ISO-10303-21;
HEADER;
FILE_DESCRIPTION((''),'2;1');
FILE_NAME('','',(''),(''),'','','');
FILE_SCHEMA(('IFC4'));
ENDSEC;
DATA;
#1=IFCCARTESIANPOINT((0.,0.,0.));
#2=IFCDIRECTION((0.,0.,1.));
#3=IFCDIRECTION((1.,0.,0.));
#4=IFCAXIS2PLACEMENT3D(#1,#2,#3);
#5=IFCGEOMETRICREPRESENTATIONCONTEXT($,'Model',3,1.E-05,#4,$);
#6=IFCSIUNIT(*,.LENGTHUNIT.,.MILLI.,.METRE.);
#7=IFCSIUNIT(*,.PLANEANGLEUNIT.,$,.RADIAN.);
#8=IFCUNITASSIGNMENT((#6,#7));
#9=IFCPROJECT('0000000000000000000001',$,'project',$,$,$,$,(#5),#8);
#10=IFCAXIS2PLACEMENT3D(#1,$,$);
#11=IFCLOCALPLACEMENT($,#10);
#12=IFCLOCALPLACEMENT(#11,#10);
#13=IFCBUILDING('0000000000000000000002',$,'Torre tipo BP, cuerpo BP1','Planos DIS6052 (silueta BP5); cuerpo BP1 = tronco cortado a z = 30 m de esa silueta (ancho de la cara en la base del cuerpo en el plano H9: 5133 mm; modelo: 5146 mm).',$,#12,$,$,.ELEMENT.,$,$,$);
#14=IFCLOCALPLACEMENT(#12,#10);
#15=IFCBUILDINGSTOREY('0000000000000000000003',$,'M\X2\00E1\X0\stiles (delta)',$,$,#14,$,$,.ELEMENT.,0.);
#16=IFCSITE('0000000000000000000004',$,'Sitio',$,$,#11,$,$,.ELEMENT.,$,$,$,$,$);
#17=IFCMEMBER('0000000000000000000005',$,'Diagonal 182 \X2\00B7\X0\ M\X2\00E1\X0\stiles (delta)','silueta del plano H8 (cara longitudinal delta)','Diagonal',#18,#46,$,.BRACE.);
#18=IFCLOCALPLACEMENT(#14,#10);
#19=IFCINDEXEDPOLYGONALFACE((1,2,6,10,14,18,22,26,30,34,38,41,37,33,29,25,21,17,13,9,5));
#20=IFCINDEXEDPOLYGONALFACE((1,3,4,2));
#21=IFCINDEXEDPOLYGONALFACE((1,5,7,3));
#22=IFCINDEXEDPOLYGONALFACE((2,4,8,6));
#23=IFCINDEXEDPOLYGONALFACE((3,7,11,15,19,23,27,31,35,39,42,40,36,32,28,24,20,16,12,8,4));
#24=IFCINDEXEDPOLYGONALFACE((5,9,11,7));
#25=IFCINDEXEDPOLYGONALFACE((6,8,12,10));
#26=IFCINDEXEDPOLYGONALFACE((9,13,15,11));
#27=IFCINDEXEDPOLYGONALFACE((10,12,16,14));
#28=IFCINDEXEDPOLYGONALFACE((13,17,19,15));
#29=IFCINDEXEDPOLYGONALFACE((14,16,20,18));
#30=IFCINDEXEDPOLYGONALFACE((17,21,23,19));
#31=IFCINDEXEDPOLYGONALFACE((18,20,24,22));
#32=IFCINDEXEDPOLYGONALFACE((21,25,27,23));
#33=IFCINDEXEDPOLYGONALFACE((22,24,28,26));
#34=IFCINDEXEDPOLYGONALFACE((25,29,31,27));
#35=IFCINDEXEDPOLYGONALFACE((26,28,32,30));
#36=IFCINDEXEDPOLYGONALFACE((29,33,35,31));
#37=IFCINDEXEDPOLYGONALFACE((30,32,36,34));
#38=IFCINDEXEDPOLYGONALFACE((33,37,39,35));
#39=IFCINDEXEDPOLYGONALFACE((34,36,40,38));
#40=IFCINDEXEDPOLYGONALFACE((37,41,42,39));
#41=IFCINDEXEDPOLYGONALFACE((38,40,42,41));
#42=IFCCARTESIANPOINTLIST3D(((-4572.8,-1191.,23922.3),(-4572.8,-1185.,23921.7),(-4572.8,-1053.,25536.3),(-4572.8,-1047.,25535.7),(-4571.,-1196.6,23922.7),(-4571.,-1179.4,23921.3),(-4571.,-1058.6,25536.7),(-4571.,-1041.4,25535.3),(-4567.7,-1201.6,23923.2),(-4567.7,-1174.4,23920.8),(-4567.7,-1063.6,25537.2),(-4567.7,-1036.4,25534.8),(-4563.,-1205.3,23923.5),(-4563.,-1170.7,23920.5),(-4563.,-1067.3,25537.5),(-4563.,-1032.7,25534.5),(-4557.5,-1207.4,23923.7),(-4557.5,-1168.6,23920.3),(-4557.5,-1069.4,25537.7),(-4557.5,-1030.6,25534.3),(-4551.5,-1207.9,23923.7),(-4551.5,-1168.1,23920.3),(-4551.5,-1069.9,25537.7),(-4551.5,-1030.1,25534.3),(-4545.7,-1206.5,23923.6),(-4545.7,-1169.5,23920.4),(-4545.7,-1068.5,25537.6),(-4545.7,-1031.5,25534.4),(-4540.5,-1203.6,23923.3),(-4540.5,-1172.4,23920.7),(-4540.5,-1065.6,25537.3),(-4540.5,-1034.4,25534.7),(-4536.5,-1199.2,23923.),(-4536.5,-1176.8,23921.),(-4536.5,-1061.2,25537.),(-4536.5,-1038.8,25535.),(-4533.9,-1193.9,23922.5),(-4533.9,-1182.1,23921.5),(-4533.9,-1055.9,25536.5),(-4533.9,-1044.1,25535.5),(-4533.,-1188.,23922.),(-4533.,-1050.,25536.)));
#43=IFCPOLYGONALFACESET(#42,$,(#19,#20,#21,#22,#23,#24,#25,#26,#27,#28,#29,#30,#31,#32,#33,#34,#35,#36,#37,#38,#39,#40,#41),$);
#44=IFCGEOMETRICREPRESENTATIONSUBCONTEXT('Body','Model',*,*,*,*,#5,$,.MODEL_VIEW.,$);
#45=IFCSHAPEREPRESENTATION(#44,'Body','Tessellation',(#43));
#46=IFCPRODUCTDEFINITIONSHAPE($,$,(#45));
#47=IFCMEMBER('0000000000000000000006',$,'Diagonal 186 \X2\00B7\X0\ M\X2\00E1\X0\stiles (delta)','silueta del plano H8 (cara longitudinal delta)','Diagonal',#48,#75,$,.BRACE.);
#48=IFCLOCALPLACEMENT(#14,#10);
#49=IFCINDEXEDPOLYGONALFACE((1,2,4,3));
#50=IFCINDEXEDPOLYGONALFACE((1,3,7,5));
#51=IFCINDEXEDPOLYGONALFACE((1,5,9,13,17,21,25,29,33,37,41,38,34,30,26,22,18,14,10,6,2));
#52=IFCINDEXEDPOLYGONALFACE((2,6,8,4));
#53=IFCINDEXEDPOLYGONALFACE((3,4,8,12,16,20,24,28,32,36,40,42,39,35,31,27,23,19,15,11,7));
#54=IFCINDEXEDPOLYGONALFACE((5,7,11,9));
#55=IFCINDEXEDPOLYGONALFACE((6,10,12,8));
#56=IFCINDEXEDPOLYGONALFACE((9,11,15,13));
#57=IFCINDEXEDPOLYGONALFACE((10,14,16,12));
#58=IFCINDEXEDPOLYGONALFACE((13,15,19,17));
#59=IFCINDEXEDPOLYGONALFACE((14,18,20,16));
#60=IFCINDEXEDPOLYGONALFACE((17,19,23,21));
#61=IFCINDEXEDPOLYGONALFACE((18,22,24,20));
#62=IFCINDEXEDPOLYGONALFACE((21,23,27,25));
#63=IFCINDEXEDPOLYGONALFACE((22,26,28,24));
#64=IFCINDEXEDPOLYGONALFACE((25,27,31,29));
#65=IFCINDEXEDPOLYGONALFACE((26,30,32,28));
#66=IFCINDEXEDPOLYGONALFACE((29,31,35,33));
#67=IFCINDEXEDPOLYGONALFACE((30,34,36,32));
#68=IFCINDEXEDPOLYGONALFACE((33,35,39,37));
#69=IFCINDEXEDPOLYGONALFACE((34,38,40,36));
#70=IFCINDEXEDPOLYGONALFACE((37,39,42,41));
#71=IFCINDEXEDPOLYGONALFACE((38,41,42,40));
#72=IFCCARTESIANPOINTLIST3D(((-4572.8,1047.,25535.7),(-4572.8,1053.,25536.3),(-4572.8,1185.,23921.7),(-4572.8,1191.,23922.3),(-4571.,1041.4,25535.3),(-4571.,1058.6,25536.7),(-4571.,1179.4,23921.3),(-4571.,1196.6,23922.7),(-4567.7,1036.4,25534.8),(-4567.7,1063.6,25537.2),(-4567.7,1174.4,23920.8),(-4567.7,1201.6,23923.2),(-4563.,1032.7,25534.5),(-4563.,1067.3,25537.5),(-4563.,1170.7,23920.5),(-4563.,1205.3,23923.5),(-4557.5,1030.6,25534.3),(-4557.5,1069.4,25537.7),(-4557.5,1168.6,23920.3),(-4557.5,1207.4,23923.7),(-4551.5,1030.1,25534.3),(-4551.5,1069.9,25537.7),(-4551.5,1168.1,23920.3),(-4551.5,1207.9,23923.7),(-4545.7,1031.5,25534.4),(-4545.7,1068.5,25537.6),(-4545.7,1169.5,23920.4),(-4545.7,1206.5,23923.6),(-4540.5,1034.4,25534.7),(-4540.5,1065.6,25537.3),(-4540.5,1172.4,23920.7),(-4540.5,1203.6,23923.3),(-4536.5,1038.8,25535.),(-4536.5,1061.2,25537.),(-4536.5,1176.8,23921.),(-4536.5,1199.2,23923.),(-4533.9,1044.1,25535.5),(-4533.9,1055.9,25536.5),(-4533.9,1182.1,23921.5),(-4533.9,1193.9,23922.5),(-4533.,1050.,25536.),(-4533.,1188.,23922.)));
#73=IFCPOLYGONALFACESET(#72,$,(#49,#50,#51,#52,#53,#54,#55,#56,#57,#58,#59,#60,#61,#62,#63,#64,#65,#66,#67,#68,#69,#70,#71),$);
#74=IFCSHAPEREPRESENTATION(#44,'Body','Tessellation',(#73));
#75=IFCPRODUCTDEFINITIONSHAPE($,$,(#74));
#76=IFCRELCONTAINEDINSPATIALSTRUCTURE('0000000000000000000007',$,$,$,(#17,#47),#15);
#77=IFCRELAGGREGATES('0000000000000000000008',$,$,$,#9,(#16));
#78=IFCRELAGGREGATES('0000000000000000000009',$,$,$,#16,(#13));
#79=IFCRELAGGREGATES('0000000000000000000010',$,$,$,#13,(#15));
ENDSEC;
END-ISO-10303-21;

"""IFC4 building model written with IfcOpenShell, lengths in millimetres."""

from ifc_helpers import new_model, si_unit, frame, origin, origin_with_axes, place, context, subcontext, project, spatial, circle, extrude, element, save


model = new_model("IFC4")

# Units and contexts
model_context = context("Model", 3, precision=1e-05, world=origin_with_axes())
body_context = subcontext(model_context, "Body", "Model", "MODEL_VIEW")
ifc_project = project(units=[si_unit("LENGTHUNIT", "METRE", prefix="MILLI"), si_unit("PLANEANGLEUNIT", "RADIAN")], contexts=[model_context])

# Site, building, storey
site_placement = place(None, origin())
site = spatial("IfcSite", under=ifc_project, at=site_placement, Name="Sitio", CompositionType="ELEMENT")
building_placement = place(site_placement, origin())
building = spatial("IfcBuilding", under=site, at=building_placement, Name="Torre tipo BP, cuerpo BP1", Description="Planos DIS6052 (silueta BP5); cuerpo BP1 = tronco cortado a z = 30 m de esa silueta (ancho de la cara en la base del cuerpo en el plano H9: 5133 mm; modelo: 5146 mm).", CompositionType="ELEMENT")
storey_placement = place(building_placement, origin())
storey = spatial("IfcBuildingStorey", under=building, at=storey_placement, Name="Mástiles (delta)", CompositionType="ELEMENT", Elevation=0.0)

# Members
for number, where, z_axis, x_axis, name in (
    (1, (-4553.0, -1050.0, 25536.0), (0.0, -0.085191, -0.996365), (1.0, 0.0, 0.0), "Diagonal 182 · Mástiles (delta)"),
    (2, (-4553.0, 1050.0, 25536.0), (0.0, 0.085191, -0.996365), (1.0, 0.0, 0.0), "Diagonal 186 · Mástiles (delta)"),
):
    element("IfcMember", number, at=place(storey_placement, frame(where, z_axis=z_axis, x_axis=x_axis)), inside=storey, Name=name, Description="silueta del plano H8 (cara longitudinal delta)", ObjectType="Diagonal", PredefinedType="BRACE", context=body_context, shape_type="SweptSolid", body=[
        extrude(circle(Radius=20.0), None, (0.0, 0.0, 1.0), 1619.9),
    ])

save(model, "model.ifc")
